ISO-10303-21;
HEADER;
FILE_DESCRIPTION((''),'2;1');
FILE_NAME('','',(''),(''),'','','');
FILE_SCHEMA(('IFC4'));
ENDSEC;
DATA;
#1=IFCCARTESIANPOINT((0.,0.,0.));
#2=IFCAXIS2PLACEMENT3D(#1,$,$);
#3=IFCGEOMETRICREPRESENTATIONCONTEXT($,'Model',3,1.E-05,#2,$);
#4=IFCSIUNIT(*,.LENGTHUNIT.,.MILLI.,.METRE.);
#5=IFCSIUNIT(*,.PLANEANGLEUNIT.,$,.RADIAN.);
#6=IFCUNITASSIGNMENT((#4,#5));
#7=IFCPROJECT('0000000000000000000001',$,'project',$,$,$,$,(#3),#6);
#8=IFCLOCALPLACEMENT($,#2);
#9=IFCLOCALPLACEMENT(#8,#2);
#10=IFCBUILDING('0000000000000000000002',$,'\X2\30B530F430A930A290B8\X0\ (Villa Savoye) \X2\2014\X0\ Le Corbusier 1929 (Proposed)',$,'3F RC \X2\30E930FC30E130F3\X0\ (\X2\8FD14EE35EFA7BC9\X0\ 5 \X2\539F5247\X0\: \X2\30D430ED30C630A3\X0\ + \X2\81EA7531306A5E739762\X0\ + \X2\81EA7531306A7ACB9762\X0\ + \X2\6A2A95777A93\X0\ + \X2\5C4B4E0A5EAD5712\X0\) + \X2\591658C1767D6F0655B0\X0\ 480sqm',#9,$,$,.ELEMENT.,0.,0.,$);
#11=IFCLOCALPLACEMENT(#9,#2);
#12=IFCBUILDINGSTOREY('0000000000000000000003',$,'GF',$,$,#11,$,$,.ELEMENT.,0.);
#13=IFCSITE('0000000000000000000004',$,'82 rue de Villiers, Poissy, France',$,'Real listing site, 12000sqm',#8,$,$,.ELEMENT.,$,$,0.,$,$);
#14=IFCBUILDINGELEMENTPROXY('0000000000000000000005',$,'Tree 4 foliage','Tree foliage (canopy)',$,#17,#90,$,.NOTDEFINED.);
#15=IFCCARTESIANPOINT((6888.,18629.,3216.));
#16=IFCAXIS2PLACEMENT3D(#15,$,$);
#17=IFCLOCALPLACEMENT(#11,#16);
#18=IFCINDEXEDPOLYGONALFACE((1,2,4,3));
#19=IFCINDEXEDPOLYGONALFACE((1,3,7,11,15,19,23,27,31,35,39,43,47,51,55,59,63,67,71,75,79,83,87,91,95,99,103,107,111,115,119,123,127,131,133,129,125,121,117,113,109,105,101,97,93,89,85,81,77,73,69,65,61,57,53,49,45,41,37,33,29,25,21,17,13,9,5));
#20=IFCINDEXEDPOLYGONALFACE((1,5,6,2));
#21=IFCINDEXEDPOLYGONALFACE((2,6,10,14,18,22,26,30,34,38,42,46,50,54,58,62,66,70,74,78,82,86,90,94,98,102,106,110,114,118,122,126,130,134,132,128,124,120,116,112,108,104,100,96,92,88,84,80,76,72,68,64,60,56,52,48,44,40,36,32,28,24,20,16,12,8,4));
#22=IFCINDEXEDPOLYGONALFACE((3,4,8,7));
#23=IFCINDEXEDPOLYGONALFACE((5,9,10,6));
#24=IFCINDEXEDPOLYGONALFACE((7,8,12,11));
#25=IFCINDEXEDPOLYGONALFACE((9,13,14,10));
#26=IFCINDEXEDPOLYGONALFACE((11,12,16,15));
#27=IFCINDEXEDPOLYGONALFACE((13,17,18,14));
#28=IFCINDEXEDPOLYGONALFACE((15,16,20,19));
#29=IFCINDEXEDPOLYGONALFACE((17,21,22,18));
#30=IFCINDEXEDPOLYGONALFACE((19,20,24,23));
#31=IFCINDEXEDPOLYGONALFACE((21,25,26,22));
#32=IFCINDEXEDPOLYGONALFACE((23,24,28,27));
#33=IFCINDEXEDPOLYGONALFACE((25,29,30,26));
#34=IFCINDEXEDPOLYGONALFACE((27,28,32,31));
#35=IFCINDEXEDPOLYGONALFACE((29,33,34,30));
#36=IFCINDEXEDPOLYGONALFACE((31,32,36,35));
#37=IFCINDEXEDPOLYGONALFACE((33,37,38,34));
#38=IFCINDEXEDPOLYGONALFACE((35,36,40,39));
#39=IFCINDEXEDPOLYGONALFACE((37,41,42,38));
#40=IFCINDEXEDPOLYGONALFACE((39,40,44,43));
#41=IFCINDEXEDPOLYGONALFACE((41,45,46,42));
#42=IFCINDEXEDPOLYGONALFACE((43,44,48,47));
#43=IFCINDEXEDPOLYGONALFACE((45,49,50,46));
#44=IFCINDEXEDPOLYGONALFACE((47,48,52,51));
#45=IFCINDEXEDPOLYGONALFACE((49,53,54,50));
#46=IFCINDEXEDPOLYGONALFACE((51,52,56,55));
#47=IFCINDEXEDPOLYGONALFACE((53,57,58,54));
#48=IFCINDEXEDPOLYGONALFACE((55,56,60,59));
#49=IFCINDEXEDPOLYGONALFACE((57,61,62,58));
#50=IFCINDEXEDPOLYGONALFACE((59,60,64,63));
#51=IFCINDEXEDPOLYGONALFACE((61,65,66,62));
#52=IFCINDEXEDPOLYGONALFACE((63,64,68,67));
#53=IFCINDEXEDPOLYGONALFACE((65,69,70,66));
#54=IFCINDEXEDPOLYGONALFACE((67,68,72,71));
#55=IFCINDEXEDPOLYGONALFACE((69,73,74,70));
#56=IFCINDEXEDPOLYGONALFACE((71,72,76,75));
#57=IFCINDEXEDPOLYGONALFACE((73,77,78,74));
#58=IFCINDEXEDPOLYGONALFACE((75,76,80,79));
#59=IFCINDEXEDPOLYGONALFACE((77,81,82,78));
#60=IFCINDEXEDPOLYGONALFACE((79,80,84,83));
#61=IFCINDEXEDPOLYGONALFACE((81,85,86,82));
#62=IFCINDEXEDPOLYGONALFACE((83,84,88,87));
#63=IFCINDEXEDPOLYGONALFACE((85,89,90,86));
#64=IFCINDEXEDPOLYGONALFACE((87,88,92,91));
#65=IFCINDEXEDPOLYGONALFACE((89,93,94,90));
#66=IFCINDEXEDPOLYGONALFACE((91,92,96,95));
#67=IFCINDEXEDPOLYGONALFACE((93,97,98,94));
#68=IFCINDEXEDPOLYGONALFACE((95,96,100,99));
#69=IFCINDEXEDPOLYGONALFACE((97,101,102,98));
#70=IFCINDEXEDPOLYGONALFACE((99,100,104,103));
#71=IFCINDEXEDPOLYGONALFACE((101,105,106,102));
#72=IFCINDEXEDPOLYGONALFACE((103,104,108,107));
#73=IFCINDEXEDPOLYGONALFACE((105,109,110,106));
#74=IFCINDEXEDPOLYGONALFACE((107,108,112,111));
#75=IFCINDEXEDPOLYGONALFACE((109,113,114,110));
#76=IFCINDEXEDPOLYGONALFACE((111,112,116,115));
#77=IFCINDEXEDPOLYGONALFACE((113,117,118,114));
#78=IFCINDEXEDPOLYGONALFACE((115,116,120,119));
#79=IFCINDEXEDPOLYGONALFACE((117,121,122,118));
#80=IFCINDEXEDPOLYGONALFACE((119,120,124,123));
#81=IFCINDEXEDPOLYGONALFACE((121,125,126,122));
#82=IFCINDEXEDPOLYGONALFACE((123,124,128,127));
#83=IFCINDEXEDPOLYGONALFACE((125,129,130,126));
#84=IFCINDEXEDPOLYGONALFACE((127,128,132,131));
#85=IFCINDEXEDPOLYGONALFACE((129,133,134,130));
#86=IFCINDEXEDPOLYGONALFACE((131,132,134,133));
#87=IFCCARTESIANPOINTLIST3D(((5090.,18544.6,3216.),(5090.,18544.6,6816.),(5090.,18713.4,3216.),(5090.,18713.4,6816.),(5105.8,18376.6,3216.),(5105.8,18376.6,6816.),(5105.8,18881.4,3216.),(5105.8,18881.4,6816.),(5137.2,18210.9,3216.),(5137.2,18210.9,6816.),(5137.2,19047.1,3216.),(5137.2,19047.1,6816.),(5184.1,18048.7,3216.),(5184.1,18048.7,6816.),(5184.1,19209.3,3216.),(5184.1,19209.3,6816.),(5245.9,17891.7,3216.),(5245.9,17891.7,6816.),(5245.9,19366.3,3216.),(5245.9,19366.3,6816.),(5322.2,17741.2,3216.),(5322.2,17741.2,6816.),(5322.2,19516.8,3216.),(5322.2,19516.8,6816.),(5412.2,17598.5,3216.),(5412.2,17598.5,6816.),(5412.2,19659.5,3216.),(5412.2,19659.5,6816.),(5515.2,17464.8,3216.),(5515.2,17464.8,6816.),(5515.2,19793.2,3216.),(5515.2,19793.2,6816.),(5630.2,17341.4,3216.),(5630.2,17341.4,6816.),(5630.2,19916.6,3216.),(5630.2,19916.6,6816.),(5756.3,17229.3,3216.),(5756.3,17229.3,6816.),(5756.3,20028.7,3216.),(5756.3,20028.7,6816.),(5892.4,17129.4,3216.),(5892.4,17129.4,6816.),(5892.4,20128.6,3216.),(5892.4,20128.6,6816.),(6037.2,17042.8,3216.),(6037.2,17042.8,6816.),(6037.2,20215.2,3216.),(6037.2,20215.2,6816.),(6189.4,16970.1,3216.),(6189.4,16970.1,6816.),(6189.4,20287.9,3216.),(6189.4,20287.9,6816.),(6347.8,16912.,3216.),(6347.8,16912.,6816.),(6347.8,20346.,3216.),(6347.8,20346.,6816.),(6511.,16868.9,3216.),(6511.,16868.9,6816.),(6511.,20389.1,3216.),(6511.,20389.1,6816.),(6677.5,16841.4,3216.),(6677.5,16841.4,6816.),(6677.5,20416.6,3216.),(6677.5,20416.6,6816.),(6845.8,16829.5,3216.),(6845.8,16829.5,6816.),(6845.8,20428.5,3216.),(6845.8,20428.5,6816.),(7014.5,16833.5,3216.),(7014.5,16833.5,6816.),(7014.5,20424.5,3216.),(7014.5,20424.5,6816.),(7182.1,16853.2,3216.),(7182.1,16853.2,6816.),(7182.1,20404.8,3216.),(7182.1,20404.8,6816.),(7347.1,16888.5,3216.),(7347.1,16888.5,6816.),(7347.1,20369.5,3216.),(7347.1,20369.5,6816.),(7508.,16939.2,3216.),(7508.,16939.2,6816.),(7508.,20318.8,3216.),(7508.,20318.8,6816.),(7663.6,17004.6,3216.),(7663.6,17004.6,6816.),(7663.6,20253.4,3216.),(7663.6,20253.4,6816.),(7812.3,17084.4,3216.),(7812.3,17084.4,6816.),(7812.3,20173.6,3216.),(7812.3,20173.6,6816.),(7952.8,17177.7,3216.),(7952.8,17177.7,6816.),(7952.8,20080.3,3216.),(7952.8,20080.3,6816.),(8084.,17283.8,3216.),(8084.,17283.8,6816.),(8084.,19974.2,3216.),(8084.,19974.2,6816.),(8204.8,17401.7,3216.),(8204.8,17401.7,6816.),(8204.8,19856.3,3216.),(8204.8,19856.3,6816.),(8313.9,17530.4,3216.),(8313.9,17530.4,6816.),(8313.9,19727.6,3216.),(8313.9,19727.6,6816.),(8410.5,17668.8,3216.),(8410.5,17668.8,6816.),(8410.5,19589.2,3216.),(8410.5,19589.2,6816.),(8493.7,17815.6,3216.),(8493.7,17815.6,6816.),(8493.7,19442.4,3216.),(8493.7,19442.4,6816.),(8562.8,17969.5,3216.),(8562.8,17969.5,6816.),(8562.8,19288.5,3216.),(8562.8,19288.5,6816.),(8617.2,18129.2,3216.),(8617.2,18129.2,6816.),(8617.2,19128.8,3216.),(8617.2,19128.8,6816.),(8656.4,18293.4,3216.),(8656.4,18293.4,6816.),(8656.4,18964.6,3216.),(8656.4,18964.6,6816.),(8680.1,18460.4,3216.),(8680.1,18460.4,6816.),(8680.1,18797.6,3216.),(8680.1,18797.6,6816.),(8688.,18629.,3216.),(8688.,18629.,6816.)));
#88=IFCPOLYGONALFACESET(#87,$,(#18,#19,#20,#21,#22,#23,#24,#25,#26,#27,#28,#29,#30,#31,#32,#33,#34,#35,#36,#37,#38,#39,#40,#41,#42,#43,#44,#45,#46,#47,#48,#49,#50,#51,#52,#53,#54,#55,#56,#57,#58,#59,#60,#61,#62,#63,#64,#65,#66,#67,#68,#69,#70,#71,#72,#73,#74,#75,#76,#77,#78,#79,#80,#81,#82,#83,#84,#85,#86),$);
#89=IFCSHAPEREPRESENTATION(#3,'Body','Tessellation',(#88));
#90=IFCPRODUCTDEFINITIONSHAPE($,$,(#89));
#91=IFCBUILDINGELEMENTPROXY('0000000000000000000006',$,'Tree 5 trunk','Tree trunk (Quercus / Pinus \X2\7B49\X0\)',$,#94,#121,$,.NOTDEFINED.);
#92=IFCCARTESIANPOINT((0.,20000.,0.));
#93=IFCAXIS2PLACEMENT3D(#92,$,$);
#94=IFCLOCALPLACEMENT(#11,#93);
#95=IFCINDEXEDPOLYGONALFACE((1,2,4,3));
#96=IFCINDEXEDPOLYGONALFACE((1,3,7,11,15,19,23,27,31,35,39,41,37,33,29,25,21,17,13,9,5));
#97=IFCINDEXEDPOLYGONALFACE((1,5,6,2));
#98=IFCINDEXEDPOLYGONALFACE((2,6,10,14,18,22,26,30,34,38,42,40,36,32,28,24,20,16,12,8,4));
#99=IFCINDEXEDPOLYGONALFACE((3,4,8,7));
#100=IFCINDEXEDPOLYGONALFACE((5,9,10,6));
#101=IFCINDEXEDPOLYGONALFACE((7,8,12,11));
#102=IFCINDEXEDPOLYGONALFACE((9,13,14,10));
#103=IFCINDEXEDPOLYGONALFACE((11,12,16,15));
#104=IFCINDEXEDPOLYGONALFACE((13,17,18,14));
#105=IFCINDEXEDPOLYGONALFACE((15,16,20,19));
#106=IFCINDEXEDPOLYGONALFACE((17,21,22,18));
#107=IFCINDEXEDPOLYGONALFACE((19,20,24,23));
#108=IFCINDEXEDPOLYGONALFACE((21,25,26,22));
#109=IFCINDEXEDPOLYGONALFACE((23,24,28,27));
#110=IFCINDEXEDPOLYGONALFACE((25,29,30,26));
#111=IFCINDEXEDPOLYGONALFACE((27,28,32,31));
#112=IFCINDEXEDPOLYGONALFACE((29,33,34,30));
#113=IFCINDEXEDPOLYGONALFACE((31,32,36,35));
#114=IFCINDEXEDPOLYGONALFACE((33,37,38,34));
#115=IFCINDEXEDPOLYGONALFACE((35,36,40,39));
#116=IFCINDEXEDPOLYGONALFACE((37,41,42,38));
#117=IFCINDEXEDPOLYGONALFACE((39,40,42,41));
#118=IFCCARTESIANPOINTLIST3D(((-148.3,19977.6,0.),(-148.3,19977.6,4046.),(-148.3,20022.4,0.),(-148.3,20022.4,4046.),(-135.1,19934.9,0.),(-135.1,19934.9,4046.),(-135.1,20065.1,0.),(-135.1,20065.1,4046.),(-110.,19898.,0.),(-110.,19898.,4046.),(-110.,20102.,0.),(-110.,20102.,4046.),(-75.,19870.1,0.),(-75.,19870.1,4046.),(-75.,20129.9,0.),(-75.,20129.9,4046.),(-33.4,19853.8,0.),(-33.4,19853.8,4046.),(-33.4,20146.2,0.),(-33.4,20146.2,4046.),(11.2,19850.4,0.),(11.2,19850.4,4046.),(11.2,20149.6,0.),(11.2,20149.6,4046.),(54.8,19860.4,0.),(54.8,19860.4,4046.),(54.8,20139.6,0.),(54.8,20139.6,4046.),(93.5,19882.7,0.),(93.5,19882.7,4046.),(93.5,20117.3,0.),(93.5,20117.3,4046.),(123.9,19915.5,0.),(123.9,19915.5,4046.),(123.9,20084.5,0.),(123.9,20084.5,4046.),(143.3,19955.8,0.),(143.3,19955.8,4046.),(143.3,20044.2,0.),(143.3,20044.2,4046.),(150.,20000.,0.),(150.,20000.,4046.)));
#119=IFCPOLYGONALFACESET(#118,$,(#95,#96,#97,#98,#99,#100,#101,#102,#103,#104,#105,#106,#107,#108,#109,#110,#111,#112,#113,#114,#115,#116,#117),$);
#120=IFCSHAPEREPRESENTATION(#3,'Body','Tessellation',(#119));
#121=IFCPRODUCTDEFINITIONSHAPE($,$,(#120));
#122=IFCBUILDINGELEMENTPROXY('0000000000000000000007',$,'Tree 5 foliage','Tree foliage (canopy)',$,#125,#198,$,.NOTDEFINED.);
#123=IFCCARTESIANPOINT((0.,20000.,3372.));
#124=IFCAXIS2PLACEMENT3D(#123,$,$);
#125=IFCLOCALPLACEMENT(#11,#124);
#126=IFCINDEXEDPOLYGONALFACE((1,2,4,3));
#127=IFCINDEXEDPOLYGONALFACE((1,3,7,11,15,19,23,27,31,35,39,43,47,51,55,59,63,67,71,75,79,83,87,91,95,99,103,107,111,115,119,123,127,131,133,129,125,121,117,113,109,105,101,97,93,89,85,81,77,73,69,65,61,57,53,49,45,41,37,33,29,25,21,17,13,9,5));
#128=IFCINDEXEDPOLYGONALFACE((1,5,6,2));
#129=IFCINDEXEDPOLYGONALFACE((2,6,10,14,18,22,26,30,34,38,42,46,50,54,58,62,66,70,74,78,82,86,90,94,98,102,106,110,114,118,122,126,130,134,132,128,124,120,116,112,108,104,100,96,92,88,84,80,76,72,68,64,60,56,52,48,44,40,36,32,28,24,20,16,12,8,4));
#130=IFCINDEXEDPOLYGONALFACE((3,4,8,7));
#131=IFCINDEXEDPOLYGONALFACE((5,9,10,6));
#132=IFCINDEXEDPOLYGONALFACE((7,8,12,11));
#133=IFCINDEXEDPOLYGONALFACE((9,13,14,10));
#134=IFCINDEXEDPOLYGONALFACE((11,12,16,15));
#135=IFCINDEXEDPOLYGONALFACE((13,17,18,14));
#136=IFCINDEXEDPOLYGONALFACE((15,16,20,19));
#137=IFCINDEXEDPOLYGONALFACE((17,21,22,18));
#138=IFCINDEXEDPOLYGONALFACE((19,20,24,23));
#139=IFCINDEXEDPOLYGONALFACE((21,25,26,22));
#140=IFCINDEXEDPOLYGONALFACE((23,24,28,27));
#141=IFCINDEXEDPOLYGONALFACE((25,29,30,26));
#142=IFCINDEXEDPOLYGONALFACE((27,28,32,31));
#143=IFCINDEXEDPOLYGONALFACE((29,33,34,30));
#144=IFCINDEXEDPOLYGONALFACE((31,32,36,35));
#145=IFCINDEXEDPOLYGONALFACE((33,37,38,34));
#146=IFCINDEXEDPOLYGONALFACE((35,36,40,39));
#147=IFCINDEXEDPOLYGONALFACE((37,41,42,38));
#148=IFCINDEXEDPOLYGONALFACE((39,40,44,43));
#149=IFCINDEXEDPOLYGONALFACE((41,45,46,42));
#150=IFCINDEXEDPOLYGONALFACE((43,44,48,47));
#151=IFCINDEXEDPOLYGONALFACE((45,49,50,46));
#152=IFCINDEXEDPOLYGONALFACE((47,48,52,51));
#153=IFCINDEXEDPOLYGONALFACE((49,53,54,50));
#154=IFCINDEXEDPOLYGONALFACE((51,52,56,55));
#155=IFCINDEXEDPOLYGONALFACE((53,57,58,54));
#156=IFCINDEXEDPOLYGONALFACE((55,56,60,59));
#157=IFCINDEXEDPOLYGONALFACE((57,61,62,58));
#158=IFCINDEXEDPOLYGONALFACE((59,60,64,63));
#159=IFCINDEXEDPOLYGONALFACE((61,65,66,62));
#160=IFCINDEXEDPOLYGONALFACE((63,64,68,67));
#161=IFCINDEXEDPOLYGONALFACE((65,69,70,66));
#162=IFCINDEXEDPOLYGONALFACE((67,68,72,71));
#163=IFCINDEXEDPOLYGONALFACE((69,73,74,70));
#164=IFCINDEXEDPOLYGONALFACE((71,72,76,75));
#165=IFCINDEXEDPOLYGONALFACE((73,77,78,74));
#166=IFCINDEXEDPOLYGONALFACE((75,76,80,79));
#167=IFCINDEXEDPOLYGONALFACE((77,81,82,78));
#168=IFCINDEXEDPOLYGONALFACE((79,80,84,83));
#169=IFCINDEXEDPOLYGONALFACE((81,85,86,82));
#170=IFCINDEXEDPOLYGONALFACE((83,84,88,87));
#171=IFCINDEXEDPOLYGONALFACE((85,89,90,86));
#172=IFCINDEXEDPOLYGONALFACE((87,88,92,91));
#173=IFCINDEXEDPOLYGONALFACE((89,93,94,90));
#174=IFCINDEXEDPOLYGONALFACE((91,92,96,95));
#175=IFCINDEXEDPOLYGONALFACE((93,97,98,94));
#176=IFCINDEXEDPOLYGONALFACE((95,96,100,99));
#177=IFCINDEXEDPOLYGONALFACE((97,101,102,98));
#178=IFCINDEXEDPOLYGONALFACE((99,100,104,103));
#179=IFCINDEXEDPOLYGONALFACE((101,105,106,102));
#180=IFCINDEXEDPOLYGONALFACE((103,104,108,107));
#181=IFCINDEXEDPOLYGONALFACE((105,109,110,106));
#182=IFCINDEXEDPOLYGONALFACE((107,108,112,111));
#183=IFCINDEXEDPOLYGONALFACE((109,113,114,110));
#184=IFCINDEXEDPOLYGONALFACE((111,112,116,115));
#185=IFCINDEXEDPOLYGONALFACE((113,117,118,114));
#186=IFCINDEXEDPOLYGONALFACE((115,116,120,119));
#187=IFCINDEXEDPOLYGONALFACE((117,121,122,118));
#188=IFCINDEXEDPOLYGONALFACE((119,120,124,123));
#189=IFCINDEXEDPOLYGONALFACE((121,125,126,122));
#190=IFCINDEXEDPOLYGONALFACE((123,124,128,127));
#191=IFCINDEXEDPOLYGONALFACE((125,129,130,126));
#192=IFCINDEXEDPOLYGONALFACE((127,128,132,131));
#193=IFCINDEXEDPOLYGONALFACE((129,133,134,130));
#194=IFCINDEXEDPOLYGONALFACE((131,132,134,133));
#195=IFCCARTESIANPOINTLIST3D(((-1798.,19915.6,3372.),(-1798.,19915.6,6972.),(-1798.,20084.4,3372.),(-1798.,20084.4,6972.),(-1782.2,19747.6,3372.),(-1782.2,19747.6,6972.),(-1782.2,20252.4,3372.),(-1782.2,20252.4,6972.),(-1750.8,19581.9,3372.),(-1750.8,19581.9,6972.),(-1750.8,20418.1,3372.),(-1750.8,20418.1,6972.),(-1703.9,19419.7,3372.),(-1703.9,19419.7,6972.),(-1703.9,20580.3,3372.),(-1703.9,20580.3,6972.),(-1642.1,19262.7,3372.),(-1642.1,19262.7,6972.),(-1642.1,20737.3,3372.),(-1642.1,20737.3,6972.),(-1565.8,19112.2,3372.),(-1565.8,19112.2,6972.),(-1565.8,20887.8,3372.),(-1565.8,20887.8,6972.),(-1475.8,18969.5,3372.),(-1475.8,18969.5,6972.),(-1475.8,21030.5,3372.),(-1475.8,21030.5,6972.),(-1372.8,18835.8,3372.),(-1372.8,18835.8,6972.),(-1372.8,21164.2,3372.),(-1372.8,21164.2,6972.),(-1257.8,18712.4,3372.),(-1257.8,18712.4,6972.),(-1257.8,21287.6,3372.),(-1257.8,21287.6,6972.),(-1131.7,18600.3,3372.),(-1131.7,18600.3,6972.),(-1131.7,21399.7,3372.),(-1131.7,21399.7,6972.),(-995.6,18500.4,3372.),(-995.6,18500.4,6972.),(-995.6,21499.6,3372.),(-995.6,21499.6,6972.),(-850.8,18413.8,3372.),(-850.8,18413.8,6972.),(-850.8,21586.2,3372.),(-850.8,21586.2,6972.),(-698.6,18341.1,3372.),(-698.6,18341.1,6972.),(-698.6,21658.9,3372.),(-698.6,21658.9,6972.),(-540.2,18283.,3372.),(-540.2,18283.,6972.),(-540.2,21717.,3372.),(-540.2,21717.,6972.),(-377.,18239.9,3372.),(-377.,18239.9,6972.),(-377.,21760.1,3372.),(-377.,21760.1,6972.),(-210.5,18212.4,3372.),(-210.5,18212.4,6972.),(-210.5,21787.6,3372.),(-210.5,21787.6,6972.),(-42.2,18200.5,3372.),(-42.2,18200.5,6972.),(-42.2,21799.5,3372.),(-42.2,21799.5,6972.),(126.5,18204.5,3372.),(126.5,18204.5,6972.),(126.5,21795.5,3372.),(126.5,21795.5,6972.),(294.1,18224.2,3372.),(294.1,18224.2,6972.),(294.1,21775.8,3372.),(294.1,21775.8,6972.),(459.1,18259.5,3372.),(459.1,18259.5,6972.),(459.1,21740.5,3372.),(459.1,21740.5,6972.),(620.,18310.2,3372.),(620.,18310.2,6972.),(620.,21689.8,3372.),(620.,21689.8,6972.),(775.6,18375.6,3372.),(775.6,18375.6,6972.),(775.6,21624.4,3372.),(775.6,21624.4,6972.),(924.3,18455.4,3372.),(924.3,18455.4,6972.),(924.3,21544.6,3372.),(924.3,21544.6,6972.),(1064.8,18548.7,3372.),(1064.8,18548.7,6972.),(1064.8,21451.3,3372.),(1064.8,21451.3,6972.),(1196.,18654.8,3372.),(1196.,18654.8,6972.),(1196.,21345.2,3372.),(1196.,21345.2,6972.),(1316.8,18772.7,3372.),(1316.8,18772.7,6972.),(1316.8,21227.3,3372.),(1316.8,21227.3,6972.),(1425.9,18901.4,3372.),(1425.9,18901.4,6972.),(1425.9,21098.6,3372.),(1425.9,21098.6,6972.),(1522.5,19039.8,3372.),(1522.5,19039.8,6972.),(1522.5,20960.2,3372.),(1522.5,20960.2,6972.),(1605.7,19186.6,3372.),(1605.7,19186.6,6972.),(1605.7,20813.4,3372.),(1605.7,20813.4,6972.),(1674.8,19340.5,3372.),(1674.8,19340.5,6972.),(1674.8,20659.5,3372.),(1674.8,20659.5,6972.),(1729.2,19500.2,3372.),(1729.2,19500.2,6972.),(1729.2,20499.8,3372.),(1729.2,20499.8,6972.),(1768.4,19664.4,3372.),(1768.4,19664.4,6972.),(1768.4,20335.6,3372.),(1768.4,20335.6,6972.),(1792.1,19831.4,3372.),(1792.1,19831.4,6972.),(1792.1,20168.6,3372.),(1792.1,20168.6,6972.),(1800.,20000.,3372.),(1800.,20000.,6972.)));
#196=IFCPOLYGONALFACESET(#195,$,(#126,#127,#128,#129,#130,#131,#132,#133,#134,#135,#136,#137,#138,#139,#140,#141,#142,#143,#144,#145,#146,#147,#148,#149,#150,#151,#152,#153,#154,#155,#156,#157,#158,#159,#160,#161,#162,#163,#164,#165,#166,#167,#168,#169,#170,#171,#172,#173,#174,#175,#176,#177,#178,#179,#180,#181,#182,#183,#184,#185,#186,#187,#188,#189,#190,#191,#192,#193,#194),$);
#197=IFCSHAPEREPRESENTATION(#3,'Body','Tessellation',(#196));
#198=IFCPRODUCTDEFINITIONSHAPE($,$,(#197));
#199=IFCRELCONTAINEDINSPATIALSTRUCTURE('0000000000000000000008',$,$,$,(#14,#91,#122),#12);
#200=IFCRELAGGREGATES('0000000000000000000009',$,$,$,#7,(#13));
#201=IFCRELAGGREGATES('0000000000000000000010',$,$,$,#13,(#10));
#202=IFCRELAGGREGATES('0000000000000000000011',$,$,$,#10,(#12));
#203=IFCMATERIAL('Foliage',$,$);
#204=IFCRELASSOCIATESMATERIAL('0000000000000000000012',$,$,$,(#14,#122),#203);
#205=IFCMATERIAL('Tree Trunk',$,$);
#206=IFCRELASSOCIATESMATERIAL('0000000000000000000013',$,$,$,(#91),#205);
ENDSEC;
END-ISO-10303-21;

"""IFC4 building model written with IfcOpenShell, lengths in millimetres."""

from ifc_helpers import new_model, si_unit, frame, origin, origin_2d, place, context, project, spatial, circle, extrude, material, element, save


model = new_model("IFC4")

# Units and contexts
model_context = context("Model", 3, precision=1e-05, world=origin())
ifc_project = project(units=[si_unit("LENGTHUNIT", "METRE", prefix="MILLI"), si_unit("PLANEANGLEUNIT", "RADIAN")], contexts=[model_context])

# Site, building, storey
site_placement = place(None, origin())
site = spatial("IfcSite", under=ifc_project, at=site_placement, Name="82 rue de Villiers, Poissy, France", ObjectType="Real listing site, 12000sqm", CompositionType="ELEMENT", RefElevation=0.0)
building_placement = place(site_placement, origin())
building = spatial("IfcBuilding", under=site, at=building_placement, Name="サヴォア邸 (Villa Savoye) — Le Corbusier 1929 (Proposed)", ObjectType="3F RC ラーメン (近代建築 5 原則: ピロティ + 自由な平面 + 自由な立面 + 横長窓 + 屋上庭園) + 外壁白漆喰 480sqm", CompositionType="ELEMENT", ElevationOfRefHeight=0.0, ElevationOfTerrain=0.0)
storey_placement = place(building_placement, origin())
storey = spatial("IfcBuildingStorey", under=building, at=storey_placement, Name="GF", CompositionType="ELEMENT", Elevation=0.0)

# Building element proxies
ifc_material_1 = material(Name="Tree Trunk")
ifc_material_2 = material(Name="Foliage")
proxy_1_placement = place(storey_placement, frame((6888.0, 18629.0, 3216.0)))
element("IfcBuildingElementProxy", 1, at=proxy_1_placement, inside=storey, material=ifc_material_2, Name="Tree 4 foliage", Description="Tree foliage (canopy)", PredefinedType="NOTDEFINED", context=model_context, shape_type="SweptSolid", body=[
    extrude(circle(Radius=1800.0, at=origin_2d()), frame((6888.0, 18629.0, 3216.0)), (0.0, 0.0, 1.0), 3600.0),
])
proxy_2_placement = place(storey_placement, frame((0.0, 20000.0, 0.0)))
element("IfcBuildingElementProxy", 2, at=proxy_2_placement, inside=storey, material=ifc_material_1, Name="Tree 5 trunk", Description="Tree trunk (Quercus / Pinus 等)", PredefinedType="NOTDEFINED", context=model_context, shape_type="SweptSolid", body=[
    extrude(circle(Radius=150.0, at=origin_2d()), frame((0.0, 20000.0, 0.0)), (0.0, 0.0, 1.0), 4046.0),
])
proxy_3_placement = place(storey_placement, frame((0.0, 20000.0, 3372.0)))
element("IfcBuildingElementProxy", 3, at=proxy_3_placement, inside=storey, material=ifc_material_2, Name="Tree 5 foliage", Description="Tree foliage (canopy)", PredefinedType="NOTDEFINED", context=model_context, shape_type="SweptSolid", body=[
    extrude(circle(Radius=1800.0, at=origin_2d()), frame((0.0, 20000.0, 3372.0)), (0.0, 0.0, 1.0), 3600.0),
])

save(model, "model.ifc")
